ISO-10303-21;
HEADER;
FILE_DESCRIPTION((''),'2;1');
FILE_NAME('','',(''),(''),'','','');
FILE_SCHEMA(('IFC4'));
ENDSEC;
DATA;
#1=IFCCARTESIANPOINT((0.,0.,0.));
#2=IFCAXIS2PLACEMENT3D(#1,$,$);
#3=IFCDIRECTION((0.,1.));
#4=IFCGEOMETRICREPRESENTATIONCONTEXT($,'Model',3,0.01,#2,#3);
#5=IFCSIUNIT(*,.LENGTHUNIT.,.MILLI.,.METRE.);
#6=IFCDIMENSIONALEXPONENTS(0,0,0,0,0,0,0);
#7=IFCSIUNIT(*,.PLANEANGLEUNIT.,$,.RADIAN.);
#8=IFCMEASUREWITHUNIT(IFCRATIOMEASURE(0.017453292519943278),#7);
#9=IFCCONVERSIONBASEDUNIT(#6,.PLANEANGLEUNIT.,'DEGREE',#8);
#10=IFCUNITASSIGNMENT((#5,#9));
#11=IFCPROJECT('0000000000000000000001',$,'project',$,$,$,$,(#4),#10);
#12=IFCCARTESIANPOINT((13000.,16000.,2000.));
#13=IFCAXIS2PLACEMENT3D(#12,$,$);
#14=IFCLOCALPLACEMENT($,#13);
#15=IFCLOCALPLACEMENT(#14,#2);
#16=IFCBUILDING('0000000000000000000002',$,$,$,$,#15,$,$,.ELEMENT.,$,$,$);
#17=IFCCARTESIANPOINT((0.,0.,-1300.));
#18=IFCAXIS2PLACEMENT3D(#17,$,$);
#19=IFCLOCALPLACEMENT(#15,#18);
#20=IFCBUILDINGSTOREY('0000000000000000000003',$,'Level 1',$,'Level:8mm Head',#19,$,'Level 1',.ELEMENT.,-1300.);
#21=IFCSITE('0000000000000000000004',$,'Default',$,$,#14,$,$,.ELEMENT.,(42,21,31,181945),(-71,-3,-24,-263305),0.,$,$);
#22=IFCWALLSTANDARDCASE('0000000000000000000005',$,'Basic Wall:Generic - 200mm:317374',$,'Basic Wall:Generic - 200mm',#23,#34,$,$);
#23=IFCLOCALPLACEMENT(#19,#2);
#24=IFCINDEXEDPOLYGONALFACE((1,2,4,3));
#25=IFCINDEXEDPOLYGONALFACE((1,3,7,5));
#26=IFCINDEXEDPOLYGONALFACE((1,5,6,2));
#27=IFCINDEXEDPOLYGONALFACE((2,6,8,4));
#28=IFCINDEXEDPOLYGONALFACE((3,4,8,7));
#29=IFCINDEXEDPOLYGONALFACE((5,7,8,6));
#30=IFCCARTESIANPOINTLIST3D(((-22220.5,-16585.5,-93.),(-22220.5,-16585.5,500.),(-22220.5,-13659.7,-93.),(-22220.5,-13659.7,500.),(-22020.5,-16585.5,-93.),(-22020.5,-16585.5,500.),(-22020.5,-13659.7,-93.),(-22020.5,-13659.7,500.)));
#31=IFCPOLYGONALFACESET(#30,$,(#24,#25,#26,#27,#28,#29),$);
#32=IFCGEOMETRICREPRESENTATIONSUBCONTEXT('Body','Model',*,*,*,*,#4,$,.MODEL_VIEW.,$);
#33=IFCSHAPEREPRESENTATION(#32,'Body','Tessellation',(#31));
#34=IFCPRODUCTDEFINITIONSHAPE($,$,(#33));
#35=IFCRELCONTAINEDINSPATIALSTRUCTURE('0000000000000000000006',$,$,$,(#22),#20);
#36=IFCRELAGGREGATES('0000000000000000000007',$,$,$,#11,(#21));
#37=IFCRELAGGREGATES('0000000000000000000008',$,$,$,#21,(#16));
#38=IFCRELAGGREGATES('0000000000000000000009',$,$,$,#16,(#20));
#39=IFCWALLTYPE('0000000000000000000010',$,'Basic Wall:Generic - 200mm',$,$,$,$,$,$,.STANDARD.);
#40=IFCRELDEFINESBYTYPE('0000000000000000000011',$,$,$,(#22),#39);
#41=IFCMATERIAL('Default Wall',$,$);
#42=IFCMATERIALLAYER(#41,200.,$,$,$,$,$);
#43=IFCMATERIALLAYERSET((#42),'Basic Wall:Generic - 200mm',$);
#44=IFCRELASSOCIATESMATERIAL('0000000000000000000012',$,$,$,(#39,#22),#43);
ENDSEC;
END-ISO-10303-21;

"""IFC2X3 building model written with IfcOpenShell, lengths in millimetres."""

from ifc_helpers import new_model, entity, si_unit, converted_unit, direction, frame, frame_2d, origin, place, context, subcontext, project, spatial, polyline, rectangle, extrude, clip, bounded_halfspace, material, layer, layer_set, layer_usage, type_object, element, save


model = new_model("IFC2X3")

# Units and contexts
model_context = context("Model", 3, precision=0.01, world=origin(), true_north=direction((0.0, 1.0)))
body_context = subcontext(model_context, "Body", "Model", "MODEL_VIEW")
ifc_project = project(units=[si_unit("LENGTHUNIT", "METRE", prefix="MILLI"), converted_unit("PLANEANGLEUNIT", "DEGREE", entity("IfcRatioMeasure", 0.017453292519943278), si_unit("PLANEANGLEUNIT", "RADIAN"), dimensions=[0, 0, 0, 0, 0, 0, 0])], contexts=[model_context])

# Site, building, storey
site_placement = place(None, frame((13000.0, 16000.0, 2000.0)))
site = spatial("IfcSite", under=ifc_project, at=site_placement, Name="Default", CompositionType="ELEMENT", RefLatitude=(42, 21, 31, 181945), RefLongitude=(-71, -3, -24, -263305), RefElevation=0.0)
building_placement = place(site_placement, origin())
building = spatial("IfcBuilding", under=site, at=building_placement, CompositionType="ELEMENT")
storey_placement = place(building_placement, frame((0.0, 0.0, -1300.0)))
storey = spatial("IfcBuildingStorey", under=building, at=storey_placement, Name="Level 1", ObjectType="Level:8mm Head", LongName="Level 1", CompositionType="ELEMENT", Elevation=-1300.0)

# Wall
ifc_material = material(Name="Default Wall")
ifc_layer = layer(ifc_material, 200.0)
ifc_layer_set = layer_set([ifc_layer], Name="Basic Wall:Generic - 200mm")
wall_type = type_object("IfcWallType", Name="Basic Wall:Generic - 200mm", PredefinedType="STANDARD", material=ifc_layer_set)
ifc_layer_usage_1 = layer_usage(ifc_layer_set, "AXIS2", "NEGATIVE", 100.0)
wall_1_placement = place(storey_placement, frame((-22120.5, -13659.7, -93.0), z_axis=(0.0, 0.0, 1.0), x_axis=(0.0, -1.0, 0.0)))
element("IfcWallStandardCase", 1, at=wall_1_placement, inside=storey, type_object=wall_type, material=ifc_layer_usage_1, Name="Basic Wall:Generic - 200mm:317374", ObjectType="Basic Wall:Generic - 200mm", context=body_context, shape_type="Clipping", body=[
    clip(extrude(rectangle(XDim=2925.8, YDim=200.0, at=frame_2d((1462.9, 0.0), x_axis=(-1.0, 0.0))), origin(), (0.0, 0.0, 1.0), 593.0), bounded_halfspace(frame((2925.8, -100.0, 0.0), z_axis=(0.0, 0.0, 1.0), x_axis=(0.0, -1.0, 0.0)), True, frame((2925.8, -100.0, 0.0), z_axis=(0.0, 0.0, 1.0), x_axis=(0.0, -1.0, 0.0)), polyline([(0.0, 0.0), (-60960.0, 0.0), (-60960.0, -891789.6), (0.0, -891789.6), (0.0, 0.0)]))),
])

save(model, "model.ifc")
